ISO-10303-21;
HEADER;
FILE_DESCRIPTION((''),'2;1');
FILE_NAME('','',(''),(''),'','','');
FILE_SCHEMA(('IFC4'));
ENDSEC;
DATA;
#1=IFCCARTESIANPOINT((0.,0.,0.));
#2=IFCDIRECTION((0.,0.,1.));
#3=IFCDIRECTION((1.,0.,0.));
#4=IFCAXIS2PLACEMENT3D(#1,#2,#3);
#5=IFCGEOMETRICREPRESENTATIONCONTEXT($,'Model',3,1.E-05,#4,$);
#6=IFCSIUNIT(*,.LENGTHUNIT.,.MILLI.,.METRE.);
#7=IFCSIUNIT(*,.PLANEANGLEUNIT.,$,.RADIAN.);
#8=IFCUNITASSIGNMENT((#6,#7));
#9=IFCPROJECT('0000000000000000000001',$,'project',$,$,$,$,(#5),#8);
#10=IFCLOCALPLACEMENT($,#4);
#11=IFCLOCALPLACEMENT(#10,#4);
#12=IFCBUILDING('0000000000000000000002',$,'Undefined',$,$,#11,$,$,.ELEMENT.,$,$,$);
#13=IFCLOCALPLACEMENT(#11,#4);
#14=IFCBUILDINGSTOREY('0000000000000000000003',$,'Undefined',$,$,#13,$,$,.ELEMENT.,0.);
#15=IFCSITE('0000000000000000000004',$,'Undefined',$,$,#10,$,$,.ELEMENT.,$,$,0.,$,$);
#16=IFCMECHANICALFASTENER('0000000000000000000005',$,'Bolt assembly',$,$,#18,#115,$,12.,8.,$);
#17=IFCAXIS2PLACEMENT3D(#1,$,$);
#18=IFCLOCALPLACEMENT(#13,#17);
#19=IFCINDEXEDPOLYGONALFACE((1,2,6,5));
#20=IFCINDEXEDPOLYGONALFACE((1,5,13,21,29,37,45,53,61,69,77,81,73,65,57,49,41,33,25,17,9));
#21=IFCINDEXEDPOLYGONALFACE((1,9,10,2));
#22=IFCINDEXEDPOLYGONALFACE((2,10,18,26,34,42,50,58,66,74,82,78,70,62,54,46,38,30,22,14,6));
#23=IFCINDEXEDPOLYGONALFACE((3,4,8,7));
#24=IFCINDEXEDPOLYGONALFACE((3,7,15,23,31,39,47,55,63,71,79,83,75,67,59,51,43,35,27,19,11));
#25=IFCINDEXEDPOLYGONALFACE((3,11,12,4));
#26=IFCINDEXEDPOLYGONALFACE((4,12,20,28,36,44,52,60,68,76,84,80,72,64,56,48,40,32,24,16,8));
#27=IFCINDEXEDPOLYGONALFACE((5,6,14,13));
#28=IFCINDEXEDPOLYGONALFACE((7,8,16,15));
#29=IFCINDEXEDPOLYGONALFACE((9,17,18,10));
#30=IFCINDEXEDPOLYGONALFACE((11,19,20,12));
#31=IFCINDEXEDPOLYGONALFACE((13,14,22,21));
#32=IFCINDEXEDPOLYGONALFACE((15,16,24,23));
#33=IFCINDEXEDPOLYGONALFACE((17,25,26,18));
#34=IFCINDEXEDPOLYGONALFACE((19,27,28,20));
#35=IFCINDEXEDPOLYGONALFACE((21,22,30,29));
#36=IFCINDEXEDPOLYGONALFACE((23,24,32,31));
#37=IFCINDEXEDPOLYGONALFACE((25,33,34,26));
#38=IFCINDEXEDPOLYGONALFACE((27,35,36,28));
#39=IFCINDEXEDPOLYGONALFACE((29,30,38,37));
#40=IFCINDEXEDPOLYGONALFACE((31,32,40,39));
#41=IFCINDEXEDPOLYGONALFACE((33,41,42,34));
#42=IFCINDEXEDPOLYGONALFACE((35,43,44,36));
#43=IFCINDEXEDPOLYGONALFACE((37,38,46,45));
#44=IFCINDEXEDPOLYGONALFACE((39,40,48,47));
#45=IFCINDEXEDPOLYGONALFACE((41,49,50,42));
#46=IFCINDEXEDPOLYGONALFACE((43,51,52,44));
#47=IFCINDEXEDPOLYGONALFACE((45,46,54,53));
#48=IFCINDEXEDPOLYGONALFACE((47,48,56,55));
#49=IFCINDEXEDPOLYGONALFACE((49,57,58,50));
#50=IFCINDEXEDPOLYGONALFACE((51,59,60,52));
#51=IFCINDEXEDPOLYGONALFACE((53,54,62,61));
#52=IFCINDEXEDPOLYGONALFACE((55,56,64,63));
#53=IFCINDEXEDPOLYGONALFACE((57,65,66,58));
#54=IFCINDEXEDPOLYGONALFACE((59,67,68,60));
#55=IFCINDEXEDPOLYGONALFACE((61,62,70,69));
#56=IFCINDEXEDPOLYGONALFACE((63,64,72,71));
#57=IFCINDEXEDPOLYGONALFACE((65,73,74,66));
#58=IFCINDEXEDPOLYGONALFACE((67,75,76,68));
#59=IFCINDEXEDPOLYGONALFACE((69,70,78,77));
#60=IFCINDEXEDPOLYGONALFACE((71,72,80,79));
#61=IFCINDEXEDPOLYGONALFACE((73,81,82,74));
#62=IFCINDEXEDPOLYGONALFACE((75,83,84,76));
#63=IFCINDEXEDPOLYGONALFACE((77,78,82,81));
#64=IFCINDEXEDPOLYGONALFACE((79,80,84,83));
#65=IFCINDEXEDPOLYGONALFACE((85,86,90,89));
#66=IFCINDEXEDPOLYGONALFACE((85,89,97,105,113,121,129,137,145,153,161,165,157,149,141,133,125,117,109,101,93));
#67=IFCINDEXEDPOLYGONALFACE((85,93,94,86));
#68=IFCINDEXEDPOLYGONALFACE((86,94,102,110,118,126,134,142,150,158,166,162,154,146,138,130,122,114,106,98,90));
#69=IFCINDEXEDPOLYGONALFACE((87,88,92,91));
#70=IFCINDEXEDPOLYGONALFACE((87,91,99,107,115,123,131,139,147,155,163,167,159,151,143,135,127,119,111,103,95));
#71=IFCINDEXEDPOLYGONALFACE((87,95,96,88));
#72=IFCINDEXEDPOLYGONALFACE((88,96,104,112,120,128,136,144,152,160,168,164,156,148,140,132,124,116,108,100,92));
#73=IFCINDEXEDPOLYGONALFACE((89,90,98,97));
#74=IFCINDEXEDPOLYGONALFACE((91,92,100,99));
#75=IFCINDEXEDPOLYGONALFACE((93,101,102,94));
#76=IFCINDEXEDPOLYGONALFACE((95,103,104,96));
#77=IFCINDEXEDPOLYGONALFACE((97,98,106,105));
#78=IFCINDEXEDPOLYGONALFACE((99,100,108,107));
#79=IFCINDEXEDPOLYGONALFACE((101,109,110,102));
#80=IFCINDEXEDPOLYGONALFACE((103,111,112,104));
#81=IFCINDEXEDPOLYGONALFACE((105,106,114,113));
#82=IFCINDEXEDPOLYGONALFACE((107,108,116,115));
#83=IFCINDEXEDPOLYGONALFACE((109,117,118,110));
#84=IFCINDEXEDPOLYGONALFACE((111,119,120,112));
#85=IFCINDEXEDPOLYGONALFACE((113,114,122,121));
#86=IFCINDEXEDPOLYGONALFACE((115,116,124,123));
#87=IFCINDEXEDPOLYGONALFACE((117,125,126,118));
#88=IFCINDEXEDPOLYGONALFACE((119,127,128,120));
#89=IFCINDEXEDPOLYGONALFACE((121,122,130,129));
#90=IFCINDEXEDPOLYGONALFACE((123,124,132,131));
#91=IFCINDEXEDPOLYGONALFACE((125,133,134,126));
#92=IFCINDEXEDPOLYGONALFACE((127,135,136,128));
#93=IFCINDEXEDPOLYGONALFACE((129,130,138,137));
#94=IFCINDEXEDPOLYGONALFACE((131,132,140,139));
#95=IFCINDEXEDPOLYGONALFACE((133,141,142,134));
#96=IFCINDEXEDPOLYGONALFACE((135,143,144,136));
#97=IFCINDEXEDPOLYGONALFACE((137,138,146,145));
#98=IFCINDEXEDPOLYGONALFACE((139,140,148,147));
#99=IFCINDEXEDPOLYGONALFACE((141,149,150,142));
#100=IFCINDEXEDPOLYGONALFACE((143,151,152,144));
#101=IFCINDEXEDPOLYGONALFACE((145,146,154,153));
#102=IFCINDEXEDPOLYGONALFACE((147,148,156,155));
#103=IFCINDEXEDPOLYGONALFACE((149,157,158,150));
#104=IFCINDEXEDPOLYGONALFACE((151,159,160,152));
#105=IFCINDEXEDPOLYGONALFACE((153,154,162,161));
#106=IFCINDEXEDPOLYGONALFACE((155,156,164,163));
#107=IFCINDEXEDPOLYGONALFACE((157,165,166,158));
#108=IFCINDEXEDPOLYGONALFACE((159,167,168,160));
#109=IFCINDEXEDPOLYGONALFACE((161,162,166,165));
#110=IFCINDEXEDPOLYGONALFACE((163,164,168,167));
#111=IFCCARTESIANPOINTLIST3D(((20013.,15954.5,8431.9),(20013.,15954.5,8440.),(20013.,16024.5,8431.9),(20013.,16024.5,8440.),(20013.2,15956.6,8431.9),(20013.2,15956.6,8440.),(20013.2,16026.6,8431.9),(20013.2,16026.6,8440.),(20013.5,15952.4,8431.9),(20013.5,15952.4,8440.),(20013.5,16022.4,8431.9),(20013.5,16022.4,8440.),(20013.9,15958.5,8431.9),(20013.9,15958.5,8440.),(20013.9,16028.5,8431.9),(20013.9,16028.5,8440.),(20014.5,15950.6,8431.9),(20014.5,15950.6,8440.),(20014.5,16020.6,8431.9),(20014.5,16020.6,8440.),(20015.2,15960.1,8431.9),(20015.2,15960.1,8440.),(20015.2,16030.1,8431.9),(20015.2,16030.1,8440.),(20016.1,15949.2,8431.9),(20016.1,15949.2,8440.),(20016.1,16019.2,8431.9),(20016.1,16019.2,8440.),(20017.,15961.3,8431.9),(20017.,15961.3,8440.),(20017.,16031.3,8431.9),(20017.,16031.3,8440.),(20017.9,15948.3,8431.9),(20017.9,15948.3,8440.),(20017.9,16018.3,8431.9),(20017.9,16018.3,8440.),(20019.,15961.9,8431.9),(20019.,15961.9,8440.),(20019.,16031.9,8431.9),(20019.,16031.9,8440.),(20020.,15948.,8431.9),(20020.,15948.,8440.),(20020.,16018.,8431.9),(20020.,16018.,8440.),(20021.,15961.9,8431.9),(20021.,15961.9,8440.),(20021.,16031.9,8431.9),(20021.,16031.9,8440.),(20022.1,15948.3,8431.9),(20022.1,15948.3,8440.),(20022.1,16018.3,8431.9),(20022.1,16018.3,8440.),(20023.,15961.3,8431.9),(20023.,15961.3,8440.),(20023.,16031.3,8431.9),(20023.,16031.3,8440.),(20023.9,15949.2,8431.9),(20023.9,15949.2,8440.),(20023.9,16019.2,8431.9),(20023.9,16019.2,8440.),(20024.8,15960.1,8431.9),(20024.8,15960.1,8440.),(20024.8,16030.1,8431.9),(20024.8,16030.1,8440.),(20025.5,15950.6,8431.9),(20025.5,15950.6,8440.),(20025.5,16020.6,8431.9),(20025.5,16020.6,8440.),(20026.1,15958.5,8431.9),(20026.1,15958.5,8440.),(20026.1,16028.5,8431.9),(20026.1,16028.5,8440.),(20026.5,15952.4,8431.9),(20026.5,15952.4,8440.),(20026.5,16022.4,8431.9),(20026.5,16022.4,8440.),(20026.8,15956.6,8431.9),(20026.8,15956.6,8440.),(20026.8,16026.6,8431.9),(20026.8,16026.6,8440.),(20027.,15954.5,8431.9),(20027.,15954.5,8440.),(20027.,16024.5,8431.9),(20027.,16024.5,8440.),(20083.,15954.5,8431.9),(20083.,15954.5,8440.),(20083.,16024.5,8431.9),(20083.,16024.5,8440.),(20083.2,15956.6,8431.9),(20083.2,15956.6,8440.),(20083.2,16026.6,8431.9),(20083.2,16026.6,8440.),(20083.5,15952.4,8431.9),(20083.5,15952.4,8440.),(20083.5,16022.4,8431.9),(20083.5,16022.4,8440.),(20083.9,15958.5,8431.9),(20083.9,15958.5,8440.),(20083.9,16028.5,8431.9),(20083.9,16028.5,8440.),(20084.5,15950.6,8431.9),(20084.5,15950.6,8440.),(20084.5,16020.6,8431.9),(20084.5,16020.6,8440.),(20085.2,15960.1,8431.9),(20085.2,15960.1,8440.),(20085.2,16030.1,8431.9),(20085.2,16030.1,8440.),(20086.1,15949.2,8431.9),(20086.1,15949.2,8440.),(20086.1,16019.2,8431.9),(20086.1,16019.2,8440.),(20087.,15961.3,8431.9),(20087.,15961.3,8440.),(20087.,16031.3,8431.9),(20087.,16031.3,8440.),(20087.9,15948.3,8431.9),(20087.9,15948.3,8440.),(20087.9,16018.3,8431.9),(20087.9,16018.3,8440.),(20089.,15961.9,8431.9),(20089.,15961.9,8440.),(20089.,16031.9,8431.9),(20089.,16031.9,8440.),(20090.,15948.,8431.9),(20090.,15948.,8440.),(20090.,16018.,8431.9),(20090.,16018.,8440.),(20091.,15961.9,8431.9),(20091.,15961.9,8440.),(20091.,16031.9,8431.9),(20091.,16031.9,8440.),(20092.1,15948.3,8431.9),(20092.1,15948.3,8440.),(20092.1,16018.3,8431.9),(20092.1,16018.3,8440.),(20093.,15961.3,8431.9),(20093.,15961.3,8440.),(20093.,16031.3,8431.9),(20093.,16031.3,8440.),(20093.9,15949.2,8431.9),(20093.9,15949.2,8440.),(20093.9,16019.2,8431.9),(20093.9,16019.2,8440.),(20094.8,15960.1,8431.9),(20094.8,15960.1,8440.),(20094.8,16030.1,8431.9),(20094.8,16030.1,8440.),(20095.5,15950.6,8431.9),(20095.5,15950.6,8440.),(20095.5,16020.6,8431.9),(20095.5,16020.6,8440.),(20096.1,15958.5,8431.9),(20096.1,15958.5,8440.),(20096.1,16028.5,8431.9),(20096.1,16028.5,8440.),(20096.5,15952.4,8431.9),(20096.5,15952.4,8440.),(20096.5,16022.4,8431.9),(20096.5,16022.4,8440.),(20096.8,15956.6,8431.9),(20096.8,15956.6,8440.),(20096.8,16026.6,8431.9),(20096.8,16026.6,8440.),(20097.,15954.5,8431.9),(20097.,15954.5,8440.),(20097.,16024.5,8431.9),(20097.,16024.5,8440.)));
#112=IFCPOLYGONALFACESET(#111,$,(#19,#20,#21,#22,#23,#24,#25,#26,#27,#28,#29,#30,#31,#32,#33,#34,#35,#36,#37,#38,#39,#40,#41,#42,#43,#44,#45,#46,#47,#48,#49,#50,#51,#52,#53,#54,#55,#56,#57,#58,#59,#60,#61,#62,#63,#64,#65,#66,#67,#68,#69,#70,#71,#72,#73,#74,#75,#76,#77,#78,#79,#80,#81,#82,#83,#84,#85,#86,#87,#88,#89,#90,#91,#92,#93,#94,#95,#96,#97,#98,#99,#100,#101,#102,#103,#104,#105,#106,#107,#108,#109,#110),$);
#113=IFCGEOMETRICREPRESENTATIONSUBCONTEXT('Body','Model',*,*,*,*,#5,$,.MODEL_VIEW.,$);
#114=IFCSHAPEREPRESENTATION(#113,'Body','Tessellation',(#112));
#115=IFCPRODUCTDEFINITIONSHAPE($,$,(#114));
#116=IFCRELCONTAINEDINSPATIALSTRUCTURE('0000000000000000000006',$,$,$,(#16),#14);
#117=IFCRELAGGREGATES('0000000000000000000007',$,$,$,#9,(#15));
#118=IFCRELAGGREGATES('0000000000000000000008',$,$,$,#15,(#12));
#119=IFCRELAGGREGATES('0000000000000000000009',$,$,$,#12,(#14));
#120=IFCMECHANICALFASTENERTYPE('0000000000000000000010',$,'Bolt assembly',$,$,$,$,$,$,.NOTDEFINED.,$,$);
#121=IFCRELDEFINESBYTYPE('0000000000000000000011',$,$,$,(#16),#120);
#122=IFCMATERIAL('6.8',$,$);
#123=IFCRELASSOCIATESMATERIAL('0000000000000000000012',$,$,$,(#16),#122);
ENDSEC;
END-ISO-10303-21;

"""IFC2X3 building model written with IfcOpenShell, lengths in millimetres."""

from ifc_helpers import new_model, si_unit, frame, origin_with_axes, origin_2d_with_axis, place, context, subcontext, project, spatial, circle, extrude, source, transform, mapped, material, type_object, element, save


model = new_model("IFC2X3")

# Units and contexts
model_context = context("Model", 3, precision=1e-05, world=origin_with_axes())
body_context = subcontext(model_context, "Body", "Model", "MODEL_VIEW")
ifc_project = project(units=[si_unit("LENGTHUNIT", "METRE", prefix="MILLI"), si_unit("PLANEANGLEUNIT", "RADIAN")], contexts=[model_context])

# Site, building, storey
site_placement = place(None, origin_with_axes())
site = spatial("IfcSite", under=ifc_project, at=site_placement, Name="Undefined", CompositionType="ELEMENT", RefElevation=0.0)
building_placement = place(site_placement, origin_with_axes())
building = spatial("IfcBuilding", under=site, at=building_placement, Name="Undefined", CompositionType="ELEMENT")
storey_placement = place(building_placement, origin_with_axes())
storey = spatial("IfcBuildingStorey", under=building, at=storey_placement, Name="Undefined", CompositionType="ELEMENT", Elevation=0.0)

# Mechanical fastener
ifc_material_1 = material(Name="6.8")
mechanical_fastener_type = type_object("IfcMechanicalFastenerType", Name="Bolt assembly")
shared_shape_1 = source(origin_with_axes(), body_context, "Body", "SweptSolid", [
    extrude(circle(Radius=7.0, at=origin_2d_with_axis()), frame((0.0, 0.0, 0.0), z_axis=(0.0, 1.0, 0.0), x_axis=(1.0, 0.0, 0.0)), (0.0, 0.0, 1.0), 8.1),
])
mechanical_fastener_1_placement = place(storey_placement, frame((20055.0, 16025.0, 8440.0), z_axis=(1.0, 0.0, 0.0), x_axis=(0.0, -1.0, 0.0)))
element("IfcMechanicalFastener", 1, at=mechanical_fastener_1_placement, inside=storey, type_object=mechanical_fastener_type, material=ifc_material_1, Name="Bolt assembly", NominalDiameter=12.0, NominalLength=8.0, context=body_context, shape_type="MappedRepresentation", body=[
    mapped(shared_shape_1, transform((0.0, 0.0, 35.0))),
    mapped(shared_shape_1, transform((70.0, 0.0, 35.0))),
    mapped(shared_shape_1, transform((0.0, 0.0, -35.0))),
    mapped(shared_shape_1, transform((70.0, 0.0, -35.0))),
])

save(model, "model.ifc")
